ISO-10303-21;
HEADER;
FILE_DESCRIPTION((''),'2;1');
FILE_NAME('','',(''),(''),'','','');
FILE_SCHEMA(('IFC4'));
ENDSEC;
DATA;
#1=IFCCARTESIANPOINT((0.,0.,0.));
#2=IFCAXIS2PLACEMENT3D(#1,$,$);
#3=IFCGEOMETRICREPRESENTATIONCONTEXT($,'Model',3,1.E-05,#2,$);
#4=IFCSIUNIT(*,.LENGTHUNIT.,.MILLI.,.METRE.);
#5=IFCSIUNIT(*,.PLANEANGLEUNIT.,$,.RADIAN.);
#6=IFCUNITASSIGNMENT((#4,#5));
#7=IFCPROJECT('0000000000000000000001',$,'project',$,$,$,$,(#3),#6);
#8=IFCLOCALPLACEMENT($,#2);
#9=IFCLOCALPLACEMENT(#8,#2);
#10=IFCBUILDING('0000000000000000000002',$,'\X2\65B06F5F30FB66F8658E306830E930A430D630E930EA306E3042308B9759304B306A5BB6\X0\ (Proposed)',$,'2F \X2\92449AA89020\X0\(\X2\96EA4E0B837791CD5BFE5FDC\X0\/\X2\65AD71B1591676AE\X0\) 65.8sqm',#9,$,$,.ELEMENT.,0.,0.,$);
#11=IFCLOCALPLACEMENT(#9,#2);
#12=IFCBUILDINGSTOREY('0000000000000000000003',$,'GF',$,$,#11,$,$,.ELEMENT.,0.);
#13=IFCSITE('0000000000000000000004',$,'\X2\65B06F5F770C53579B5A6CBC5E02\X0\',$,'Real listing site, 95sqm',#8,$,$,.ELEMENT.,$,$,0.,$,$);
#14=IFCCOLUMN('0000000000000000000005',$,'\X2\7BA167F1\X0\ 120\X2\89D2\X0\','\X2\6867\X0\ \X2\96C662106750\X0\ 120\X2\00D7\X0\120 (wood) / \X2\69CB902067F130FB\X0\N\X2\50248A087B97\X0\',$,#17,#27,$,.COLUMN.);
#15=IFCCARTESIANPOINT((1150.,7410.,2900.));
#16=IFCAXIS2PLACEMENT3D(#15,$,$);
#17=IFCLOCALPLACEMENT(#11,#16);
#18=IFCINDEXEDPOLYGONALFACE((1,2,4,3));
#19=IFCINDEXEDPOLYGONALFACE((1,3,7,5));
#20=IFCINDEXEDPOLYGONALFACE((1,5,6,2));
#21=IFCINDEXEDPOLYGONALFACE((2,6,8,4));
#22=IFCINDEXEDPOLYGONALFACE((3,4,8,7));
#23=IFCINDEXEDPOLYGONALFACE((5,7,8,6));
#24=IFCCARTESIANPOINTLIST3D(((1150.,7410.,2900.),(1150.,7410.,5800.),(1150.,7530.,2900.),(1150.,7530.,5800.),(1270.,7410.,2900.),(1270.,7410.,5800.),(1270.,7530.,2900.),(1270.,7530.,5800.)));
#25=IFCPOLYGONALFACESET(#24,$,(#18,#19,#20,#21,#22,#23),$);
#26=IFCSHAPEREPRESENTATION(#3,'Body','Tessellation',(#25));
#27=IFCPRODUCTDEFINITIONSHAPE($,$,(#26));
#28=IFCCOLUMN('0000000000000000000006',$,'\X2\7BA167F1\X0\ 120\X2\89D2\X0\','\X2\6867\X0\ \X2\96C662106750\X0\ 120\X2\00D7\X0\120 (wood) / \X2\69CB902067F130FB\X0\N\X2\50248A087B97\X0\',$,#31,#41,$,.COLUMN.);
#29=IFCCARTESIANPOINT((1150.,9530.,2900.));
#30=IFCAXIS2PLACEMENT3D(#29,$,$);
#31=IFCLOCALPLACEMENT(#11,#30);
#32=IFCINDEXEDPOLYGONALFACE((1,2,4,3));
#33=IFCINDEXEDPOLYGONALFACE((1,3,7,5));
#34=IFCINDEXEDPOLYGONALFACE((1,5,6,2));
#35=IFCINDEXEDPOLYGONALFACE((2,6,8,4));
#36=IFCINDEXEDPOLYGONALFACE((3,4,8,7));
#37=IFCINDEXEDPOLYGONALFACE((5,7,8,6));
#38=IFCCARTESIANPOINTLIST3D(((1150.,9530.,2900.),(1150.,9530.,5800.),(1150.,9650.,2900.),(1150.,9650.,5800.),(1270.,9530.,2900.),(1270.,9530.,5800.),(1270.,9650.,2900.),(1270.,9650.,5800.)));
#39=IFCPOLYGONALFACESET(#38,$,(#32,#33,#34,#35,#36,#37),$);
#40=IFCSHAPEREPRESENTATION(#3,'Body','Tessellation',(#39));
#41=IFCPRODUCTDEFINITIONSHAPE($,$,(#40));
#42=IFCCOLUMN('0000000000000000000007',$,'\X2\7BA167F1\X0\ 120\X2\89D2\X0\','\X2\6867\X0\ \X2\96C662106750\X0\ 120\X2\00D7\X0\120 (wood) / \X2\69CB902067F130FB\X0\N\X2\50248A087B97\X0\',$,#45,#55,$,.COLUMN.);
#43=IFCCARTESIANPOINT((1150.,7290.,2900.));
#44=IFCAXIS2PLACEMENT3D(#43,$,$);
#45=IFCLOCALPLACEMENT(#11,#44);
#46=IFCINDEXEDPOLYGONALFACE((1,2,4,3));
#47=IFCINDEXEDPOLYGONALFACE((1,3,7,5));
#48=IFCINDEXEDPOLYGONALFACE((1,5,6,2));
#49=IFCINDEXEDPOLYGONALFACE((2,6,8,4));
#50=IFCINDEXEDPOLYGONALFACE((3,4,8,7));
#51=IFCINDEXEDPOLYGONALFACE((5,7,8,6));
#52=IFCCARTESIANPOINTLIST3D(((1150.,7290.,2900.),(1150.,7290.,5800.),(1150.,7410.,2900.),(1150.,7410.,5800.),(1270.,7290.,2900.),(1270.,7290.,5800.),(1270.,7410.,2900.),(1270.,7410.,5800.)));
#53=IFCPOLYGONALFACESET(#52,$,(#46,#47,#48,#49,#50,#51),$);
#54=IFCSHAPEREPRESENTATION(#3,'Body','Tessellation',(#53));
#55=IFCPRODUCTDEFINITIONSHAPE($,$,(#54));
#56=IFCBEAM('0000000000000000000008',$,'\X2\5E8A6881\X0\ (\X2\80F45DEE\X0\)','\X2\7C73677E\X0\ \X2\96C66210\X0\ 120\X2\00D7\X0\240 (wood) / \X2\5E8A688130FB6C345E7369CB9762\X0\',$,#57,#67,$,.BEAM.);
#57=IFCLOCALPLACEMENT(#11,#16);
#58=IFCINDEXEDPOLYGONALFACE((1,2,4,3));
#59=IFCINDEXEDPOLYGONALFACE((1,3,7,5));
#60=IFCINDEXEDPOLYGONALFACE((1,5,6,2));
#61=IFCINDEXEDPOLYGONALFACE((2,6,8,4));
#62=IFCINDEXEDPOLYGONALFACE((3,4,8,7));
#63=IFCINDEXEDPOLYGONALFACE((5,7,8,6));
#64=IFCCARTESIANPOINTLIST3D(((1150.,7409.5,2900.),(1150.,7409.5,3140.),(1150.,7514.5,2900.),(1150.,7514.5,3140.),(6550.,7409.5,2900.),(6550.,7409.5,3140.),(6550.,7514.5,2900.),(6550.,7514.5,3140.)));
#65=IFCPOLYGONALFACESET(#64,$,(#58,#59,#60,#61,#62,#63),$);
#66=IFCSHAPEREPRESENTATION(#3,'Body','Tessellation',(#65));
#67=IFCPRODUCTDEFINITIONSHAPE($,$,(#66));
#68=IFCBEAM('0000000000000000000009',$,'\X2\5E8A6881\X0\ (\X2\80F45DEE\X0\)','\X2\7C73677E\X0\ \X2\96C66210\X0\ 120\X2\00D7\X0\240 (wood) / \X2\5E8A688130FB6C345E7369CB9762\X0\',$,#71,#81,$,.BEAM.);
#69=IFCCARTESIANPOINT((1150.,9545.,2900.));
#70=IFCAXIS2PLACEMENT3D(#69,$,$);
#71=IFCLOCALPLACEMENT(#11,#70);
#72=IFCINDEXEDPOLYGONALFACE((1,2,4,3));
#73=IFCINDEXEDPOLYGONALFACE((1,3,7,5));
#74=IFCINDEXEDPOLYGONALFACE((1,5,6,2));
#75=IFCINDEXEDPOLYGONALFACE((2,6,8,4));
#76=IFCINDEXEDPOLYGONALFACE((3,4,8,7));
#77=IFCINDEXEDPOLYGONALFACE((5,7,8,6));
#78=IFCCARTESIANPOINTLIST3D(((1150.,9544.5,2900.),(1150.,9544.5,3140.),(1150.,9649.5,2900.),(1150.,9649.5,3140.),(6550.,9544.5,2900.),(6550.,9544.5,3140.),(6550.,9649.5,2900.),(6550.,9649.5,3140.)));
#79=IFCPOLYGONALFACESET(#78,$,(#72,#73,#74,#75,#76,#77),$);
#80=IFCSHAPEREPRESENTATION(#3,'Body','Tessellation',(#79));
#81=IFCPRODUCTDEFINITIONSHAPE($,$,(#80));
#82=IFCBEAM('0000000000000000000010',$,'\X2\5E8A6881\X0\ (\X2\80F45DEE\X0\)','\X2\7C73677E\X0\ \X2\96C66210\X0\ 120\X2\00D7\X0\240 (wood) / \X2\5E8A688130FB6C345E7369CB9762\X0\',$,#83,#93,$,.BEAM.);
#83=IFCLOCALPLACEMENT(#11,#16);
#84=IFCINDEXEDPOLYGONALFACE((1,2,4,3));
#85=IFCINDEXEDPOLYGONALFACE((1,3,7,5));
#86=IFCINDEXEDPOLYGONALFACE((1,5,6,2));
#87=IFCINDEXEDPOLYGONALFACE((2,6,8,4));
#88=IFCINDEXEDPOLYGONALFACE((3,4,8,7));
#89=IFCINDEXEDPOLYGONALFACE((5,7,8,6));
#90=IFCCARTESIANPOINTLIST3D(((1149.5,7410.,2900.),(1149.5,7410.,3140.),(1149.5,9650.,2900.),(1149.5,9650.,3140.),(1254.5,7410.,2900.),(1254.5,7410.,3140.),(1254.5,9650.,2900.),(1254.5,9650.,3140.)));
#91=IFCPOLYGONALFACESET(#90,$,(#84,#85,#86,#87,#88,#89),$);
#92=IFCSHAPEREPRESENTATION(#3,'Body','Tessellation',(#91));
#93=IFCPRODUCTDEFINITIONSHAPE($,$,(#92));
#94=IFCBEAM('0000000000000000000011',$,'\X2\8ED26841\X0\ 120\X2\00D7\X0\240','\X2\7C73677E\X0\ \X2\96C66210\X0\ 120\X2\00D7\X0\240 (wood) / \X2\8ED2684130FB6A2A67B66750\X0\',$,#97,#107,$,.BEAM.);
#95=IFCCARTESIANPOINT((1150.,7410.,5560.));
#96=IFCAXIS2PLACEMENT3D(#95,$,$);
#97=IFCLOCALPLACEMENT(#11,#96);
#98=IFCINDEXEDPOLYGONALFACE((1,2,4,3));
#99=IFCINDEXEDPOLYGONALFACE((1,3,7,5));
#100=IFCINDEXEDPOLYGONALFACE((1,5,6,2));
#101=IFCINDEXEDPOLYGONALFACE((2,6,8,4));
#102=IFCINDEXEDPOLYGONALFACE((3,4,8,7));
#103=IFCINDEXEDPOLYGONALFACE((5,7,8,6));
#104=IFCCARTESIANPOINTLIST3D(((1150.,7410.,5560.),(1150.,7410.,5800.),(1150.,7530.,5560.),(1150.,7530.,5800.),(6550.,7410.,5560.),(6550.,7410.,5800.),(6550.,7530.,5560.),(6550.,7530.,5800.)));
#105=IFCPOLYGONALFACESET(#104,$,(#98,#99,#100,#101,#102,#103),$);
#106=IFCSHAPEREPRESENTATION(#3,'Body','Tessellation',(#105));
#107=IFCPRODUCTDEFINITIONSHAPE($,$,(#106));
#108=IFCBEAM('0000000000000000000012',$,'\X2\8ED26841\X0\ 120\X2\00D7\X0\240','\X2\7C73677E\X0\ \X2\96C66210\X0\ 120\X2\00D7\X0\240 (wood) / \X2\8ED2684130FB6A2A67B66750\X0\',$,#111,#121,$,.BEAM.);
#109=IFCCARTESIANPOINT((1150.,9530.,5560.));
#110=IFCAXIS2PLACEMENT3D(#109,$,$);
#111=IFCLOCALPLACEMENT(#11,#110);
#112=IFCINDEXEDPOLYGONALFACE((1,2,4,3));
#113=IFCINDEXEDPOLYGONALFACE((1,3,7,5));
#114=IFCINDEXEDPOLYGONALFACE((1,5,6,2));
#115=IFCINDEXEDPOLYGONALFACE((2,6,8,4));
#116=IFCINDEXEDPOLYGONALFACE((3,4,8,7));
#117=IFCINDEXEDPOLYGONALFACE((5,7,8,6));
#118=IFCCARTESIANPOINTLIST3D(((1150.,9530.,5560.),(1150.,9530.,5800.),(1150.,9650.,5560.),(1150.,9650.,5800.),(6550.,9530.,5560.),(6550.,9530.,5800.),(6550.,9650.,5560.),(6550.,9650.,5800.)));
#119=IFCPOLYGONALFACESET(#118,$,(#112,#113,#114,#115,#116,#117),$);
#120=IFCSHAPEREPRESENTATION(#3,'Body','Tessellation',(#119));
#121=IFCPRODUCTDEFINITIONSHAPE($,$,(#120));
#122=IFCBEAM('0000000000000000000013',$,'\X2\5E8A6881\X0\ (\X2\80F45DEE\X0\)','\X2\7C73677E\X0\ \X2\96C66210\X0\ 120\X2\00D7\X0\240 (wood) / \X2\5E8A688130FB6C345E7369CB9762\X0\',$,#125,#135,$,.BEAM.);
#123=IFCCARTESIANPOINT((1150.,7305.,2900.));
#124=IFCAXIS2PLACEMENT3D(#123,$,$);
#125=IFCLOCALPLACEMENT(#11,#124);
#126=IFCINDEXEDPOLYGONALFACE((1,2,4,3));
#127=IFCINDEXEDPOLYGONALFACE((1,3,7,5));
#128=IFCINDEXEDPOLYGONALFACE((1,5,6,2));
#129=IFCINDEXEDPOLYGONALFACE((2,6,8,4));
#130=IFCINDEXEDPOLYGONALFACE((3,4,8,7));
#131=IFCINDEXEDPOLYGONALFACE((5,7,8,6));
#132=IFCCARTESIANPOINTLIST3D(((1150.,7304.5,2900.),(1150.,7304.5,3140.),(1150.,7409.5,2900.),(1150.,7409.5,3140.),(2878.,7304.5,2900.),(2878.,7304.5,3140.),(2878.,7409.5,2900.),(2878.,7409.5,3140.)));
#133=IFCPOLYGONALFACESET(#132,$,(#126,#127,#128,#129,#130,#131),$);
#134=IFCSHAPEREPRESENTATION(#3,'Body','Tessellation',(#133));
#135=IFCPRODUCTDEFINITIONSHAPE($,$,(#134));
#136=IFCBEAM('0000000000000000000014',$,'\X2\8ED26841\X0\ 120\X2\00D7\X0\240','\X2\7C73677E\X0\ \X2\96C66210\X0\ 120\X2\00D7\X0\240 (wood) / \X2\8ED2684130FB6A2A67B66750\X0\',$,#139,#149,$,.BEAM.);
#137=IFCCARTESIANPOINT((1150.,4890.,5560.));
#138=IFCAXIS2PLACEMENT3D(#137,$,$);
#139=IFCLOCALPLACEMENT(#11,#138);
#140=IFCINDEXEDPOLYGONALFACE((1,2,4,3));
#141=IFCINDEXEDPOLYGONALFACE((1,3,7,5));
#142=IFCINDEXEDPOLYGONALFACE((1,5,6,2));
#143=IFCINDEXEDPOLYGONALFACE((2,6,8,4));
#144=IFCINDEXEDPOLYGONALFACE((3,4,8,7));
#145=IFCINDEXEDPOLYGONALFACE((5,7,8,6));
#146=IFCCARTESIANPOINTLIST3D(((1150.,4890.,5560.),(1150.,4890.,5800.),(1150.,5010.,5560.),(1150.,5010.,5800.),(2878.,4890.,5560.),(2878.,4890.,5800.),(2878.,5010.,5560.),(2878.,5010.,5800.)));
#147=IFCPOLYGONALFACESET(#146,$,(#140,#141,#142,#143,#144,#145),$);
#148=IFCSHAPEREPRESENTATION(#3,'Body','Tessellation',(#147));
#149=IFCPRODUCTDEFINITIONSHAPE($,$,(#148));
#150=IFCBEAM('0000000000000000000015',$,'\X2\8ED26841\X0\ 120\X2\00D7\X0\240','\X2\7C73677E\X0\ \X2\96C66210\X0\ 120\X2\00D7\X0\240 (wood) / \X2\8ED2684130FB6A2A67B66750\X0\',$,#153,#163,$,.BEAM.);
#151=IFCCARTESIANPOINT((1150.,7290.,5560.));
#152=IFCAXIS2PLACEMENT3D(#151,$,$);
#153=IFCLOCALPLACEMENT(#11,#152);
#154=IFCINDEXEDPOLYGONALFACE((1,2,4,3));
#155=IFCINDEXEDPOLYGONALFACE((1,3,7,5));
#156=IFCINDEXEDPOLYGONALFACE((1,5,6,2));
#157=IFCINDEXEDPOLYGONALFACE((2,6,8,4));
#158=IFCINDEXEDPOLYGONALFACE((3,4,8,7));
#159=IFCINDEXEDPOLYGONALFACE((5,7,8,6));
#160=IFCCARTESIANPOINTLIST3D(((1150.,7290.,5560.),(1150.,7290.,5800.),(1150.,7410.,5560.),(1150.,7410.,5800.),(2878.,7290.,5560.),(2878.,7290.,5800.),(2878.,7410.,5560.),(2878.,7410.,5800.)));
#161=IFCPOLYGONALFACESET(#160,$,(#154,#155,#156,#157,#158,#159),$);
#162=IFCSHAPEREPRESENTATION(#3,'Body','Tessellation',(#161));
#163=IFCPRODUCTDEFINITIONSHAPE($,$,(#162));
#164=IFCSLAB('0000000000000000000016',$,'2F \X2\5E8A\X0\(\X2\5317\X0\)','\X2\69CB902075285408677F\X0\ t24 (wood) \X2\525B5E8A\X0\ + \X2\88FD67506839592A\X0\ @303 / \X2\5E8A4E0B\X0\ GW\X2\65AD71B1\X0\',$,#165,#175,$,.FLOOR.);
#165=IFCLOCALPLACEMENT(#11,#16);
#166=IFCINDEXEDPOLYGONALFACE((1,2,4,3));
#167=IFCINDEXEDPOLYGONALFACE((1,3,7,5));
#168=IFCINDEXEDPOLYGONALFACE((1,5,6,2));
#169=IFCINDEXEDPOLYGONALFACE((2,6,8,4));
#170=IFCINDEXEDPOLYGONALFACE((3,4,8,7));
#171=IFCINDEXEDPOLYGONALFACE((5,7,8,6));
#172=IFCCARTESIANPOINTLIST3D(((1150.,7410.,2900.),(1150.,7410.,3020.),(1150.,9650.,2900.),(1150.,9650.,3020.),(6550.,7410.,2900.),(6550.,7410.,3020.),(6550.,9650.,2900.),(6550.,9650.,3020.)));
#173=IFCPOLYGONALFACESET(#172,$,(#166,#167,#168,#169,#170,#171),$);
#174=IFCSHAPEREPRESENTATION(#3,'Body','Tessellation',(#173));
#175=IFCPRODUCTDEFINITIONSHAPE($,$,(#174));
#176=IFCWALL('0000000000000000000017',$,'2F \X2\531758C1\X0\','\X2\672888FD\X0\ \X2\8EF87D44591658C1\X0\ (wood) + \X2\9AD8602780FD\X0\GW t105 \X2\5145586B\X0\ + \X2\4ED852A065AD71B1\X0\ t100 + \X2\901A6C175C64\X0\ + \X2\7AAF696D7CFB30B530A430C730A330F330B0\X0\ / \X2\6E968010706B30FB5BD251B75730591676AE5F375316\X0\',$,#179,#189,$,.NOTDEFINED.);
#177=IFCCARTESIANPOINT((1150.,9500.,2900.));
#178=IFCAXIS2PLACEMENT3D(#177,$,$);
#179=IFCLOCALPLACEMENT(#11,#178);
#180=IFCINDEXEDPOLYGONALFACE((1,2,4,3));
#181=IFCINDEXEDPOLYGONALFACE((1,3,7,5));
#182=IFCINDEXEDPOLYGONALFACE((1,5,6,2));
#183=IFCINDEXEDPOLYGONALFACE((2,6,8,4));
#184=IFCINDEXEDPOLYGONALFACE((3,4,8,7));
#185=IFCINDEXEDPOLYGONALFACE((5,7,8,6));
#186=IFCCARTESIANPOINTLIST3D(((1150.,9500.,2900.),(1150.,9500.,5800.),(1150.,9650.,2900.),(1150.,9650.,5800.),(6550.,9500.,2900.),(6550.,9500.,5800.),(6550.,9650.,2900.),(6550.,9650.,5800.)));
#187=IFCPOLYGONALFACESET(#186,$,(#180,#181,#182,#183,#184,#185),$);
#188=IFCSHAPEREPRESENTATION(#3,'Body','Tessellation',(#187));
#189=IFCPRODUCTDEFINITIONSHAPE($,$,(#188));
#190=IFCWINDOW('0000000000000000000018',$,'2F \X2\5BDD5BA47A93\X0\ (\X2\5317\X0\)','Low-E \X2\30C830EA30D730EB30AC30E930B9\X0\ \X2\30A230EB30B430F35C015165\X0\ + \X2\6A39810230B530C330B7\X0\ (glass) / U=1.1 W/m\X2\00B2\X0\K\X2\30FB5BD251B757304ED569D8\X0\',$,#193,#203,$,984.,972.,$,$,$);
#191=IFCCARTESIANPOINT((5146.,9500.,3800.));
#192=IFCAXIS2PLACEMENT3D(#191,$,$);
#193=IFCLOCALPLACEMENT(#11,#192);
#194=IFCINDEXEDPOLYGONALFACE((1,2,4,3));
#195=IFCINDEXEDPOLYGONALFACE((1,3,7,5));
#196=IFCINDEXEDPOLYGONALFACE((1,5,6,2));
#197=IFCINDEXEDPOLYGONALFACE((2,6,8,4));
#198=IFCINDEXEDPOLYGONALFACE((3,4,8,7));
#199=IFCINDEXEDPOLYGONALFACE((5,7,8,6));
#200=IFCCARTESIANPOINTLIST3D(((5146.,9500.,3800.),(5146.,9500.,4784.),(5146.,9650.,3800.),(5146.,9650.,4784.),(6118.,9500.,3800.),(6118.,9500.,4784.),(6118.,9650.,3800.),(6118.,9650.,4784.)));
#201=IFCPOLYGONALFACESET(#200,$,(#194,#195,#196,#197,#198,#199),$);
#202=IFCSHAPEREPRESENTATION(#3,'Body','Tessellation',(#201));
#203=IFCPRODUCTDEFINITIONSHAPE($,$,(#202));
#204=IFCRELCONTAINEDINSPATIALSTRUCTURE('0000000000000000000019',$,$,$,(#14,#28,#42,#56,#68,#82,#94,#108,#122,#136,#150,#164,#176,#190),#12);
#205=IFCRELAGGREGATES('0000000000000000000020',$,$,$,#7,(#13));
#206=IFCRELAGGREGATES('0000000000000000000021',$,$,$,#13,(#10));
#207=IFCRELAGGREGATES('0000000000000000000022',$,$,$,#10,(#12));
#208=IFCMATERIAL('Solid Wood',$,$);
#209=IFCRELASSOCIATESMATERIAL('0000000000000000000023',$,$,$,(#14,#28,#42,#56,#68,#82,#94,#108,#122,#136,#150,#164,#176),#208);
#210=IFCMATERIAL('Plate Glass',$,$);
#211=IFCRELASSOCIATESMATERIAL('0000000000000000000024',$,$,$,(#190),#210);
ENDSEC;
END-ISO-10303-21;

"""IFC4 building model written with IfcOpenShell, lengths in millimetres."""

from ifc_helpers import new_model, si_unit, frame, frame_2d, origin, place, context, project, spatial, rectangle, extrude, material, element, fill, save


model = new_model("IFC4")

# Units and contexts
model_context = context("Model", 3, precision=1e-05, world=origin())
ifc_project = project(units=[si_unit("LENGTHUNIT", "METRE", prefix="MILLI"), si_unit("PLANEANGLEUNIT", "RADIAN")], contexts=[model_context])

# Site, building, storey
site_placement = place(None, origin())
site = spatial("IfcSite", under=ifc_project, at=site_placement, Name="新潟県南魚沼市", ObjectType="Real listing site, 95sqm", CompositionType="ELEMENT", RefElevation=0.0)
building_placement = place(site_placement, origin())
building = spatial("IfcBuilding", under=site, at=building_placement, Name="新潟・書斎とライブラリのある静かな家 (Proposed)", ObjectType="2F 鉄骨造(雪下荷重対応/断熱外皮) 65.8sqm", CompositionType="ELEMENT", ElevationOfRefHeight=0.0, ElevationOfTerrain=0.0)
storey_placement = place(building_placement, origin())
storey = spatial("IfcBuildingStorey", under=building, at=storey_placement, Name="GF", CompositionType="ELEMENT", Elevation=0.0)

# Columns
ifc_material_1 = material(Name="Solid Wood")
column_1_placement = place(storey_placement, frame((1150.0, 7410.0, 2900.0)))
element("IfcColumn", 1, at=column_1_placement, inside=storey, material=ifc_material_1, Name="管柱 120角", Description="桧 集成材 120×120 (wood) / 構造柱・N値計算", PredefinedType="COLUMN", context=model_context, shape_type="SweptSolid", body=[
    extrude(rectangle(XDim=120.0, YDim=120.0, at=frame_2d((60.0, 60.0))), frame((1150.0, 7410.0, 2900.0)), (0.0, 0.0, 1.0), 2900.0),
])
column_2_placement = place(storey_placement, frame((1150.0, 9530.0, 2900.0)))
element("IfcColumn", 2, at=column_2_placement, inside=storey, material=ifc_material_1, Name="管柱 120角", Description="桧 集成材 120×120 (wood) / 構造柱・N値計算", PredefinedType="COLUMN", context=model_context, shape_type="SweptSolid", body=[
    extrude(rectangle(XDim=120.0, YDim=120.0, at=frame_2d((60.0, 60.0))), frame((1150.0, 9530.0, 2900.0)), (0.0, 0.0, 1.0), 2900.0),
])
column_3_placement = place(storey_placement, frame((1150.0, 7290.0, 2900.0)))
element("IfcColumn", 3, at=column_3_placement, inside=storey, material=ifc_material_1, Name="管柱 120角", Description="桧 集成材 120×120 (wood) / 構造柱・N値計算", PredefinedType="COLUMN", context=model_context, shape_type="SweptSolid", body=[
    extrude(rectangle(XDim=120.0, YDim=120.0, at=frame_2d((60.0, 60.0))), frame((1150.0, 7290.0, 2900.0)), (0.0, 0.0, 1.0), 2900.0),
])

# Beams
beam_1_placement = place(storey_placement, frame((1150.0, 7410.0, 2900.0)))
element("IfcBeam", 4, at=beam_1_placement, inside=storey, material=ifc_material_1, Name="床梁 (胴差)", Description="米松 集成 120×240 (wood) / 床梁・水平構面", PredefinedType="BEAM", context=model_context, shape_type="SweptSolid", body=[
    extrude(rectangle(XDim=5400.0, YDim=105.0, at=frame_2d((2700.0, 52.0))), frame((1150.0, 7410.0, 2900.0)), (0.0, 0.0, 1.0), 240.0),
])
beam_2_placement = place(storey_placement, frame((1150.0, 9545.0, 2900.0)))
element("IfcBeam", 5, at=beam_2_placement, inside=storey, material=ifc_material_1, Name="床梁 (胴差)", Description="米松 集成 120×240 (wood) / 床梁・水平構面", PredefinedType="BEAM", context=model_context, shape_type="SweptSolid", body=[
    extrude(rectangle(XDim=5400.0, YDim=105.0, at=frame_2d((2700.0, 52.0))), frame((1150.0, 9545.0, 2900.0)), (0.0, 0.0, 1.0), 240.0),
])
beam_3_placement = place(storey_placement, frame((1150.0, 7410.0, 2900.0)))
element("IfcBeam", 6, at=beam_3_placement, inside=storey, material=ifc_material_1, Name="床梁 (胴差)", Description="米松 集成 120×240 (wood) / 床梁・水平構面", PredefinedType="BEAM", context=model_context, shape_type="SweptSolid", body=[
    extrude(rectangle(XDim=105.0, YDim=2240.0, at=frame_2d((52.0, 1120.0))), frame((1150.0, 7410.0, 2900.0)), (0.0, 0.0, 1.0), 240.0),
])
beam_4_placement = place(storey_placement, frame((1150.0, 7410.0, 5560.0)))
element("IfcBeam", 7, at=beam_4_placement, inside=storey, material=ifc_material_1, Name="軒桁 120×240", Description="米松 集成 120×240 (wood) / 軒桁・横架材", PredefinedType="BEAM", context=model_context, shape_type="SweptSolid", body=[
    extrude(rectangle(XDim=5400.0, YDim=120.0, at=frame_2d((2700.0, 60.0))), frame((1150.0, 7410.0, 5560.0)), (0.0, 0.0, 1.0), 240.0),
])
beam_5_placement = place(storey_placement, frame((1150.0, 9530.0, 5560.0)))
element("IfcBeam", 8, at=beam_5_placement, inside=storey, material=ifc_material_1, Name="軒桁 120×240", Description="米松 集成 120×240 (wood) / 軒桁・横架材", PredefinedType="BEAM", context=model_context, shape_type="SweptSolid", body=[
    extrude(rectangle(XDim=5400.0, YDim=120.0, at=frame_2d((2700.0, 60.0))), frame((1150.0, 9530.0, 5560.0)), (0.0, 0.0, 1.0), 240.0),
])
beam_6_placement = place(storey_placement, frame((1150.0, 7305.0, 2900.0)))
element("IfcBeam", 9, at=beam_6_placement, inside=storey, material=ifc_material_1, Name="床梁 (胴差)", Description="米松 集成 120×240 (wood) / 床梁・水平構面", PredefinedType="BEAM", context=model_context, shape_type="SweptSolid", body=[
    extrude(rectangle(XDim=1728.0, YDim=105.0, at=frame_2d((864.0, 52.0))), frame((1150.0, 7305.0, 2900.0)), (0.0, 0.0, 1.0), 240.0),
])
beam_7_placement = place(storey_placement, frame((1150.0, 4890.0, 5560.0)))
element("IfcBeam", 10, at=beam_7_placement, inside=storey, material=ifc_material_1, Name="軒桁 120×240", Description="米松 集成 120×240 (wood) / 軒桁・横架材", PredefinedType="BEAM", context=model_context, shape_type="SweptSolid", body=[
    extrude(rectangle(XDim=1728.0, YDim=120.0, at=frame_2d((864.0, 60.0))), frame((1150.0, 4890.0, 5560.0)), (0.0, 0.0, 1.0), 240.0),
])
beam_8_placement = place(storey_placement, frame((1150.0, 7290.0, 5560.0)))
element("IfcBeam", 11, at=beam_8_placement, inside=storey, material=ifc_material_1, Name="軒桁 120×240", Description="米松 集成 120×240 (wood) / 軒桁・横架材", PredefinedType="BEAM", context=model_context, shape_type="SweptSolid", body=[
    extrude(rectangle(XDim=1728.0, YDim=120.0, at=frame_2d((864.0, 60.0))), frame((1150.0, 7290.0, 5560.0)), (0.0, 0.0, 1.0), 240.0),
])

# Slab
slab_placement = place(storey_placement, frame((1150.0, 7410.0, 2900.0)))
element("IfcSlab", 12, at=slab_placement, inside=storey, material=ifc_material_1, Name="2F 床(北)", Description="構造用合板 t24 (wood) 剛床 + 製材根太 @303 / 床下 GW断熱", PredefinedType="FLOOR", context=model_context, shape_type="SweptSolid", body=[
    extrude(rectangle(XDim=5400.0, YDim=2240.0, at=frame_2d((2700.0, 1120.0))), frame((1150.0, 7410.0, 2900.0)), (0.0, 0.0, 1.0), 120.0),
])

# Wall, opening, window
wall_placement = place(storey_placement, frame((1150.0, 9500.0, 2900.0)))
wall = element("IfcWall", 13, at=wall_placement, inside=storey, material=ifc_material_1, Name="2F 北壁", Description="木製 軸組外壁 (wood) + 高性能GW t105 充填 + 付加断熱 t100 + 通気層 + 窯業系サイディング / 準耐火・寒冷地外皮強化", PredefinedType="NOTDEFINED", context=model_context, shape_type="SweptSolid", body=[
    extrude(rectangle(XDim=5400.0, YDim=150.0, at=frame_2d((2700.0, 75.0))), frame((1150.0, 9500.0, 2900.0)), (0.0, 0.0, 1.0), 2900.0),
])
opening_placement = place(storey_placement, frame((5146.0, 9500.0, 3800.0)))
opening = element("IfcOpeningElement", 14, at=opening_placement, cuts=wall, PredefinedType="NOTDEFINED", context=model_context, shape_type="SweptSolid", body=[
    extrude(rectangle(XDim=972.0, YDim=150.0, at=frame_2d((486.0, 75.0))), frame((5146.0, 9500.0, 3800.0)), (0.0, 0.0, 1.0), 984.0),
])
ifc_material_2 = material(Name="Plate Glass")
window_placement = place(storey_placement, frame((5146.0, 9500.0, 3800.0)))
window = element("IfcWindow", 15, at=window_placement, inside=storey, material=ifc_material_2, Name="2F 寝室窓 (北)", Description="Low-E トリプルガラス アルゴン封入 + 樹脂サッシ (glass) / U=1.1 W/m²K・寒冷地仕様", OverallHeight=984.0, OverallWidth=972.0, context=model_context, shape_type="SweptSolid", body=[
    extrude(rectangle(XDim=972.0, YDim=150.0, at=frame_2d((486.0, 75.0))), frame((5146.0, 9500.0, 3800.0)), (0.0, 0.0, 1.0), 984.0),
])
fill(opening, window)

save(model, "model.ifc")
